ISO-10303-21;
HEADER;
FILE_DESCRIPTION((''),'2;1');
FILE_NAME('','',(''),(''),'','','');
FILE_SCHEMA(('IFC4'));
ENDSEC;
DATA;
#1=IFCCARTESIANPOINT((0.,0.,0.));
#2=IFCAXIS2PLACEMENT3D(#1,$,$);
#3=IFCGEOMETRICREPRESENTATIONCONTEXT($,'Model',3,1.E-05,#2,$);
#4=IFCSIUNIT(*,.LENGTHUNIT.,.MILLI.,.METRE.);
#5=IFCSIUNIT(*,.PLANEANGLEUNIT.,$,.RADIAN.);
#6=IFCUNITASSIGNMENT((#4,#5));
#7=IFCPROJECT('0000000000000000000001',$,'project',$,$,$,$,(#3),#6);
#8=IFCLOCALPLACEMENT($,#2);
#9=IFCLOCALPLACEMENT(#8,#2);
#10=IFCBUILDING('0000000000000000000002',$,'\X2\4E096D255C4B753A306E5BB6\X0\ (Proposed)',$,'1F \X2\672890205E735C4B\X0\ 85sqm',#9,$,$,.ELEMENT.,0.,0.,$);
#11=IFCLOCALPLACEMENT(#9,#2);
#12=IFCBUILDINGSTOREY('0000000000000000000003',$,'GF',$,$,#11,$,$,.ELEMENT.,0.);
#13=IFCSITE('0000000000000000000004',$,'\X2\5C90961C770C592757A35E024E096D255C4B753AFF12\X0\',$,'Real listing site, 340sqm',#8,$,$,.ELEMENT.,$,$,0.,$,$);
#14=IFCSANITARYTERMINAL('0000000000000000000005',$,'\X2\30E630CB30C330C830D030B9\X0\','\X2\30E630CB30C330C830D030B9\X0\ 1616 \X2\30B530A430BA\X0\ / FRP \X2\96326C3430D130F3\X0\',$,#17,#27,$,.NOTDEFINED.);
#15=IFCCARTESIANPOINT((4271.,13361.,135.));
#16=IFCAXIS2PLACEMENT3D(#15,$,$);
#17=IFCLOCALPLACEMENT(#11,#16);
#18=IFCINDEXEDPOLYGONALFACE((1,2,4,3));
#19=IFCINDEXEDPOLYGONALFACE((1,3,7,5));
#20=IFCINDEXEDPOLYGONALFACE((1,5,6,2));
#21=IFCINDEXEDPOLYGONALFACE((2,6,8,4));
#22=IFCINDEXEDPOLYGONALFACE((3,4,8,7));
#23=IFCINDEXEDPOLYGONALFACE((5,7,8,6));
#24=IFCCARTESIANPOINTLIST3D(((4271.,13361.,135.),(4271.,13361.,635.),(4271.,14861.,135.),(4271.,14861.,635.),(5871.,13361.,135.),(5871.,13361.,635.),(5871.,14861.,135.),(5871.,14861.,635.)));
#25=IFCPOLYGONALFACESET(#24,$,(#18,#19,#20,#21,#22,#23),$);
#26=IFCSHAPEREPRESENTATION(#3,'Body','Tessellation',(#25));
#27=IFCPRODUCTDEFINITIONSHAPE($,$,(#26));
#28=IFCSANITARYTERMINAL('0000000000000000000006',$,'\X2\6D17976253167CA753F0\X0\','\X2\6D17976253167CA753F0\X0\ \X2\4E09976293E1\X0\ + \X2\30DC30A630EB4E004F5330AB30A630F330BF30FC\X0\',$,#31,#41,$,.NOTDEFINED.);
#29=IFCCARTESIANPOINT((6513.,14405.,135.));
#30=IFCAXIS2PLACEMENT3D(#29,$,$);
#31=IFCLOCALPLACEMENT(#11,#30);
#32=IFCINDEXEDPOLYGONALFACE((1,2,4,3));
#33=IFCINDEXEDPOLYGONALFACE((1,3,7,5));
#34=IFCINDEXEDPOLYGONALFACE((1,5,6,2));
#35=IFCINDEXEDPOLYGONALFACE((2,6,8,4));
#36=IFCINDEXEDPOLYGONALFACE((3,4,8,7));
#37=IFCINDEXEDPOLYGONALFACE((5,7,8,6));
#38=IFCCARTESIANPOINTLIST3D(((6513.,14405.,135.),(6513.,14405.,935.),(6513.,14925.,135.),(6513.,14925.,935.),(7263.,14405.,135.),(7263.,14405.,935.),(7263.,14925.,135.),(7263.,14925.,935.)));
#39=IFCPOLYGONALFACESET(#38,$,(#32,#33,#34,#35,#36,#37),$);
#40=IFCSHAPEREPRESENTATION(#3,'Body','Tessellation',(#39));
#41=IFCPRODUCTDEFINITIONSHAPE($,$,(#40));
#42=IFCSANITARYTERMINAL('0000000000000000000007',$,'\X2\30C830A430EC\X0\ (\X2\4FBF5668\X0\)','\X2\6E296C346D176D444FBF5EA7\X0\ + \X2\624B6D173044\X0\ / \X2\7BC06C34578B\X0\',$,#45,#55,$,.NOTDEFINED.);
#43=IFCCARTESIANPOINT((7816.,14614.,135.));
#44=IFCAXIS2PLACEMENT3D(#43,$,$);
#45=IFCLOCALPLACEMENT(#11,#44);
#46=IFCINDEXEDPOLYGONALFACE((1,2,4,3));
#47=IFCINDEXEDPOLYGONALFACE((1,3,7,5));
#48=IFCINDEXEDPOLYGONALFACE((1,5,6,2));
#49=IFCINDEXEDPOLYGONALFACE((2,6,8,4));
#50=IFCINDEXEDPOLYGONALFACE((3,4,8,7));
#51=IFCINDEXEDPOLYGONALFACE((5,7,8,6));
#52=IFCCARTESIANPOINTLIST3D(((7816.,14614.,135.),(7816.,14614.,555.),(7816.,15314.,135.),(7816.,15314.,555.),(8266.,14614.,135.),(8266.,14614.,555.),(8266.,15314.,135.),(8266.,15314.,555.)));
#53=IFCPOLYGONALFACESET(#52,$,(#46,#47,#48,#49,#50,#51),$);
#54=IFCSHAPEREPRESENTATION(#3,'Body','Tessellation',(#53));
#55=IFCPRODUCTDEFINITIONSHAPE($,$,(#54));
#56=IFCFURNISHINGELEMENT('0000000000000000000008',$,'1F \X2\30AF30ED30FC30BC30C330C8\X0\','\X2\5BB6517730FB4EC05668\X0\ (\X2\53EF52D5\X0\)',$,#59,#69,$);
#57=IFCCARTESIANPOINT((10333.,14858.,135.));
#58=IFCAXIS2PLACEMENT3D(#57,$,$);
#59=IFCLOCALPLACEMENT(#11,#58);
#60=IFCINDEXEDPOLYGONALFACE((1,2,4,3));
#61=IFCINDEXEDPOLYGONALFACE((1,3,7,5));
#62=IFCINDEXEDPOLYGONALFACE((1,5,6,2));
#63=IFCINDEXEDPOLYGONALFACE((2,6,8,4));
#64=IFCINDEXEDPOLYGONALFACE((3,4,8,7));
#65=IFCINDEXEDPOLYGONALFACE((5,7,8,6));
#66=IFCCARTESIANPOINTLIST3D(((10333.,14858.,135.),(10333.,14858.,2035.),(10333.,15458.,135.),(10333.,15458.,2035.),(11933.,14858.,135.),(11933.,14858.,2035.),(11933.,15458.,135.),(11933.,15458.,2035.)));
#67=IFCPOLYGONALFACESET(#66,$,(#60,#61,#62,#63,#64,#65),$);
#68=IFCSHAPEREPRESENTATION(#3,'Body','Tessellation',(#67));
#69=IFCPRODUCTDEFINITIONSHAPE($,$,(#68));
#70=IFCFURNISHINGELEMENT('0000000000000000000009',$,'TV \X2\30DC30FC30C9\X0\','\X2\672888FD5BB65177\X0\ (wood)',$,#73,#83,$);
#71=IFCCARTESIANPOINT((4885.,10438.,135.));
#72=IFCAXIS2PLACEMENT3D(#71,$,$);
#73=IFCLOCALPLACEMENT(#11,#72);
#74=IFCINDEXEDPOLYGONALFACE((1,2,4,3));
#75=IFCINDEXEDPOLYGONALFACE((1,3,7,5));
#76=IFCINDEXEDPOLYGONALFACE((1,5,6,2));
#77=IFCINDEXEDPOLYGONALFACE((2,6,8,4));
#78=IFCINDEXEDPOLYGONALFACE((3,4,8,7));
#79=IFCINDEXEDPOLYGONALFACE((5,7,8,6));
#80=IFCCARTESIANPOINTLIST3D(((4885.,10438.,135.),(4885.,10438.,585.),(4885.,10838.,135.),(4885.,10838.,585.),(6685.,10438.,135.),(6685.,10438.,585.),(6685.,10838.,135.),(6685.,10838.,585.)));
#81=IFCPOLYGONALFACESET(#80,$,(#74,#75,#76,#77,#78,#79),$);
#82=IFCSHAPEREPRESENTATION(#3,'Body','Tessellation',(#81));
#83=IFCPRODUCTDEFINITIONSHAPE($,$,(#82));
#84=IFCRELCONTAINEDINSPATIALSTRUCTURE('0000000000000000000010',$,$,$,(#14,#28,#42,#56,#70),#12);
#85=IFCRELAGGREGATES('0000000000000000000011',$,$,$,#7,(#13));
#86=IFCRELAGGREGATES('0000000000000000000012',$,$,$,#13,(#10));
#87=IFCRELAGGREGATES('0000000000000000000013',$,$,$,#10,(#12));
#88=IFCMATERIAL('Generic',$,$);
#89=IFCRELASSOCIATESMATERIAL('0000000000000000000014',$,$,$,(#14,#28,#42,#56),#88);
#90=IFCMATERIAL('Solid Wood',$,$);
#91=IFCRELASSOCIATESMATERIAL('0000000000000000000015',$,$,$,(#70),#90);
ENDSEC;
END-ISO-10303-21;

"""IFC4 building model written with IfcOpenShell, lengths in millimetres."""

from ifc_helpers import new_model, si_unit, frame, frame_2d, origin, place, context, project, spatial, rectangle, extrude, material, element, save


model = new_model("IFC4")

# Units and contexts
model_context = context("Model", 3, precision=1e-05, world=origin())
ifc_project = project(units=[si_unit("LENGTHUNIT", "METRE", prefix="MILLI"), si_unit("PLANEANGLEUNIT", "RADIAN")], contexts=[model_context])

# Site, building, storey
site_placement = place(None, origin())
site = spatial("IfcSite", under=ifc_project, at=site_placement, Name="岐阜県大垣市三津屋町２", ObjectType="Real listing site, 340sqm", CompositionType="ELEMENT", RefElevation=0.0)
building_placement = place(site_placement, origin())
building = spatial("IfcBuilding", under=site, at=building_placement, Name="三津屋町の家 (Proposed)", ObjectType="1F 木造平屋 85sqm", CompositionType="ELEMENT", ElevationOfRefHeight=0.0, ElevationOfTerrain=0.0)
storey_placement = place(building_placement, origin())
storey = spatial("IfcBuildingStorey", under=building, at=storey_placement, Name="GF", CompositionType="ELEMENT", Elevation=0.0)

# Shared definitions
ifc_material_1 = material(Name="Solid Wood")

# Sanitary terminals
ifc_material_2 = material(Name="Generic")
sanitary_terminal_1_placement = place(storey_placement, frame((4271.0, 13361.0, 135.0)))
element("IfcSanitaryTerminal", 1, at=sanitary_terminal_1_placement, inside=storey, material=ifc_material_2, Name="ユニットバス", Description="ユニットバス 1616 サイズ / FRP 防水パン", PredefinedType="NOTDEFINED", context=model_context, shape_type="SweptSolid", body=[
    extrude(rectangle(XDim=1600.0, YDim=1500.0, at=frame_2d((800.0, 750.0))), frame((4271.0, 13361.0, 135.0)), (0.0, 0.0, 1.0), 500.0),
])
sanitary_terminal_2_placement = place(storey_placement, frame((6513.0, 14405.0, 135.0)))
element("IfcSanitaryTerminal", 2, at=sanitary_terminal_2_placement, inside=storey, material=ifc_material_2, Name="洗面化粧台", Description="洗面化粧台 三面鏡 + ボウル一体カウンター", PredefinedType="NOTDEFINED", context=model_context, shape_type="SweptSolid", body=[
    extrude(rectangle(XDim=750.0, YDim=520.0, at=frame_2d((375.0, 260.0))), frame((6513.0, 14405.0, 135.0)), (0.0, 0.0, 1.0), 800.0),
])
sanitary_terminal_3_placement = place(storey_placement, frame((7816.0, 14614.0, 135.0)))
element("IfcSanitaryTerminal", 3, at=sanitary_terminal_3_placement, inside=storey, material=ifc_material_2, Name="トイレ (便器)", Description="温水洗浄便座 + 手洗い / 節水型", PredefinedType="NOTDEFINED", context=model_context, shape_type="SweptSolid", body=[
    extrude(rectangle(XDim=450.0, YDim=700.0, at=frame_2d((225.0, 350.0))), frame((7816.0, 14614.0, 135.0)), (0.0, 0.0, 1.0), 420.0),
])

# Furnishing elements
furnishing_1_placement = place(storey_placement, frame((10333.0, 14858.0, 135.0)))
element("IfcFurnishingElement", 4, at=furnishing_1_placement, inside=storey, material=ifc_material_2, Name="1F クローゼット", Description="家具・什器 (可動)", context=model_context, shape_type="SweptSolid", body=[
    extrude(rectangle(XDim=1600.0, YDim=600.0, at=frame_2d((800.0, 300.0))), frame((10333.0, 14858.0, 135.0)), (0.0, 0.0, 1.0), 1900.0),
])
furnishing_2_placement = place(storey_placement, frame((4885.0, 10438.0, 135.0)))
element("IfcFurnishingElement", 5, at=furnishing_2_placement, inside=storey, material=ifc_material_1, Name="TV ボード", Description="木製家具 (wood)", context=model_context, shape_type="SweptSolid", body=[
    extrude(rectangle(XDim=1800.0, YDim=400.0, at=frame_2d((900.0, 200.0))), frame((4885.0, 10438.0, 135.0)), (0.0, 0.0, 1.0), 450.0),
])

save(model, "model.ifc")
